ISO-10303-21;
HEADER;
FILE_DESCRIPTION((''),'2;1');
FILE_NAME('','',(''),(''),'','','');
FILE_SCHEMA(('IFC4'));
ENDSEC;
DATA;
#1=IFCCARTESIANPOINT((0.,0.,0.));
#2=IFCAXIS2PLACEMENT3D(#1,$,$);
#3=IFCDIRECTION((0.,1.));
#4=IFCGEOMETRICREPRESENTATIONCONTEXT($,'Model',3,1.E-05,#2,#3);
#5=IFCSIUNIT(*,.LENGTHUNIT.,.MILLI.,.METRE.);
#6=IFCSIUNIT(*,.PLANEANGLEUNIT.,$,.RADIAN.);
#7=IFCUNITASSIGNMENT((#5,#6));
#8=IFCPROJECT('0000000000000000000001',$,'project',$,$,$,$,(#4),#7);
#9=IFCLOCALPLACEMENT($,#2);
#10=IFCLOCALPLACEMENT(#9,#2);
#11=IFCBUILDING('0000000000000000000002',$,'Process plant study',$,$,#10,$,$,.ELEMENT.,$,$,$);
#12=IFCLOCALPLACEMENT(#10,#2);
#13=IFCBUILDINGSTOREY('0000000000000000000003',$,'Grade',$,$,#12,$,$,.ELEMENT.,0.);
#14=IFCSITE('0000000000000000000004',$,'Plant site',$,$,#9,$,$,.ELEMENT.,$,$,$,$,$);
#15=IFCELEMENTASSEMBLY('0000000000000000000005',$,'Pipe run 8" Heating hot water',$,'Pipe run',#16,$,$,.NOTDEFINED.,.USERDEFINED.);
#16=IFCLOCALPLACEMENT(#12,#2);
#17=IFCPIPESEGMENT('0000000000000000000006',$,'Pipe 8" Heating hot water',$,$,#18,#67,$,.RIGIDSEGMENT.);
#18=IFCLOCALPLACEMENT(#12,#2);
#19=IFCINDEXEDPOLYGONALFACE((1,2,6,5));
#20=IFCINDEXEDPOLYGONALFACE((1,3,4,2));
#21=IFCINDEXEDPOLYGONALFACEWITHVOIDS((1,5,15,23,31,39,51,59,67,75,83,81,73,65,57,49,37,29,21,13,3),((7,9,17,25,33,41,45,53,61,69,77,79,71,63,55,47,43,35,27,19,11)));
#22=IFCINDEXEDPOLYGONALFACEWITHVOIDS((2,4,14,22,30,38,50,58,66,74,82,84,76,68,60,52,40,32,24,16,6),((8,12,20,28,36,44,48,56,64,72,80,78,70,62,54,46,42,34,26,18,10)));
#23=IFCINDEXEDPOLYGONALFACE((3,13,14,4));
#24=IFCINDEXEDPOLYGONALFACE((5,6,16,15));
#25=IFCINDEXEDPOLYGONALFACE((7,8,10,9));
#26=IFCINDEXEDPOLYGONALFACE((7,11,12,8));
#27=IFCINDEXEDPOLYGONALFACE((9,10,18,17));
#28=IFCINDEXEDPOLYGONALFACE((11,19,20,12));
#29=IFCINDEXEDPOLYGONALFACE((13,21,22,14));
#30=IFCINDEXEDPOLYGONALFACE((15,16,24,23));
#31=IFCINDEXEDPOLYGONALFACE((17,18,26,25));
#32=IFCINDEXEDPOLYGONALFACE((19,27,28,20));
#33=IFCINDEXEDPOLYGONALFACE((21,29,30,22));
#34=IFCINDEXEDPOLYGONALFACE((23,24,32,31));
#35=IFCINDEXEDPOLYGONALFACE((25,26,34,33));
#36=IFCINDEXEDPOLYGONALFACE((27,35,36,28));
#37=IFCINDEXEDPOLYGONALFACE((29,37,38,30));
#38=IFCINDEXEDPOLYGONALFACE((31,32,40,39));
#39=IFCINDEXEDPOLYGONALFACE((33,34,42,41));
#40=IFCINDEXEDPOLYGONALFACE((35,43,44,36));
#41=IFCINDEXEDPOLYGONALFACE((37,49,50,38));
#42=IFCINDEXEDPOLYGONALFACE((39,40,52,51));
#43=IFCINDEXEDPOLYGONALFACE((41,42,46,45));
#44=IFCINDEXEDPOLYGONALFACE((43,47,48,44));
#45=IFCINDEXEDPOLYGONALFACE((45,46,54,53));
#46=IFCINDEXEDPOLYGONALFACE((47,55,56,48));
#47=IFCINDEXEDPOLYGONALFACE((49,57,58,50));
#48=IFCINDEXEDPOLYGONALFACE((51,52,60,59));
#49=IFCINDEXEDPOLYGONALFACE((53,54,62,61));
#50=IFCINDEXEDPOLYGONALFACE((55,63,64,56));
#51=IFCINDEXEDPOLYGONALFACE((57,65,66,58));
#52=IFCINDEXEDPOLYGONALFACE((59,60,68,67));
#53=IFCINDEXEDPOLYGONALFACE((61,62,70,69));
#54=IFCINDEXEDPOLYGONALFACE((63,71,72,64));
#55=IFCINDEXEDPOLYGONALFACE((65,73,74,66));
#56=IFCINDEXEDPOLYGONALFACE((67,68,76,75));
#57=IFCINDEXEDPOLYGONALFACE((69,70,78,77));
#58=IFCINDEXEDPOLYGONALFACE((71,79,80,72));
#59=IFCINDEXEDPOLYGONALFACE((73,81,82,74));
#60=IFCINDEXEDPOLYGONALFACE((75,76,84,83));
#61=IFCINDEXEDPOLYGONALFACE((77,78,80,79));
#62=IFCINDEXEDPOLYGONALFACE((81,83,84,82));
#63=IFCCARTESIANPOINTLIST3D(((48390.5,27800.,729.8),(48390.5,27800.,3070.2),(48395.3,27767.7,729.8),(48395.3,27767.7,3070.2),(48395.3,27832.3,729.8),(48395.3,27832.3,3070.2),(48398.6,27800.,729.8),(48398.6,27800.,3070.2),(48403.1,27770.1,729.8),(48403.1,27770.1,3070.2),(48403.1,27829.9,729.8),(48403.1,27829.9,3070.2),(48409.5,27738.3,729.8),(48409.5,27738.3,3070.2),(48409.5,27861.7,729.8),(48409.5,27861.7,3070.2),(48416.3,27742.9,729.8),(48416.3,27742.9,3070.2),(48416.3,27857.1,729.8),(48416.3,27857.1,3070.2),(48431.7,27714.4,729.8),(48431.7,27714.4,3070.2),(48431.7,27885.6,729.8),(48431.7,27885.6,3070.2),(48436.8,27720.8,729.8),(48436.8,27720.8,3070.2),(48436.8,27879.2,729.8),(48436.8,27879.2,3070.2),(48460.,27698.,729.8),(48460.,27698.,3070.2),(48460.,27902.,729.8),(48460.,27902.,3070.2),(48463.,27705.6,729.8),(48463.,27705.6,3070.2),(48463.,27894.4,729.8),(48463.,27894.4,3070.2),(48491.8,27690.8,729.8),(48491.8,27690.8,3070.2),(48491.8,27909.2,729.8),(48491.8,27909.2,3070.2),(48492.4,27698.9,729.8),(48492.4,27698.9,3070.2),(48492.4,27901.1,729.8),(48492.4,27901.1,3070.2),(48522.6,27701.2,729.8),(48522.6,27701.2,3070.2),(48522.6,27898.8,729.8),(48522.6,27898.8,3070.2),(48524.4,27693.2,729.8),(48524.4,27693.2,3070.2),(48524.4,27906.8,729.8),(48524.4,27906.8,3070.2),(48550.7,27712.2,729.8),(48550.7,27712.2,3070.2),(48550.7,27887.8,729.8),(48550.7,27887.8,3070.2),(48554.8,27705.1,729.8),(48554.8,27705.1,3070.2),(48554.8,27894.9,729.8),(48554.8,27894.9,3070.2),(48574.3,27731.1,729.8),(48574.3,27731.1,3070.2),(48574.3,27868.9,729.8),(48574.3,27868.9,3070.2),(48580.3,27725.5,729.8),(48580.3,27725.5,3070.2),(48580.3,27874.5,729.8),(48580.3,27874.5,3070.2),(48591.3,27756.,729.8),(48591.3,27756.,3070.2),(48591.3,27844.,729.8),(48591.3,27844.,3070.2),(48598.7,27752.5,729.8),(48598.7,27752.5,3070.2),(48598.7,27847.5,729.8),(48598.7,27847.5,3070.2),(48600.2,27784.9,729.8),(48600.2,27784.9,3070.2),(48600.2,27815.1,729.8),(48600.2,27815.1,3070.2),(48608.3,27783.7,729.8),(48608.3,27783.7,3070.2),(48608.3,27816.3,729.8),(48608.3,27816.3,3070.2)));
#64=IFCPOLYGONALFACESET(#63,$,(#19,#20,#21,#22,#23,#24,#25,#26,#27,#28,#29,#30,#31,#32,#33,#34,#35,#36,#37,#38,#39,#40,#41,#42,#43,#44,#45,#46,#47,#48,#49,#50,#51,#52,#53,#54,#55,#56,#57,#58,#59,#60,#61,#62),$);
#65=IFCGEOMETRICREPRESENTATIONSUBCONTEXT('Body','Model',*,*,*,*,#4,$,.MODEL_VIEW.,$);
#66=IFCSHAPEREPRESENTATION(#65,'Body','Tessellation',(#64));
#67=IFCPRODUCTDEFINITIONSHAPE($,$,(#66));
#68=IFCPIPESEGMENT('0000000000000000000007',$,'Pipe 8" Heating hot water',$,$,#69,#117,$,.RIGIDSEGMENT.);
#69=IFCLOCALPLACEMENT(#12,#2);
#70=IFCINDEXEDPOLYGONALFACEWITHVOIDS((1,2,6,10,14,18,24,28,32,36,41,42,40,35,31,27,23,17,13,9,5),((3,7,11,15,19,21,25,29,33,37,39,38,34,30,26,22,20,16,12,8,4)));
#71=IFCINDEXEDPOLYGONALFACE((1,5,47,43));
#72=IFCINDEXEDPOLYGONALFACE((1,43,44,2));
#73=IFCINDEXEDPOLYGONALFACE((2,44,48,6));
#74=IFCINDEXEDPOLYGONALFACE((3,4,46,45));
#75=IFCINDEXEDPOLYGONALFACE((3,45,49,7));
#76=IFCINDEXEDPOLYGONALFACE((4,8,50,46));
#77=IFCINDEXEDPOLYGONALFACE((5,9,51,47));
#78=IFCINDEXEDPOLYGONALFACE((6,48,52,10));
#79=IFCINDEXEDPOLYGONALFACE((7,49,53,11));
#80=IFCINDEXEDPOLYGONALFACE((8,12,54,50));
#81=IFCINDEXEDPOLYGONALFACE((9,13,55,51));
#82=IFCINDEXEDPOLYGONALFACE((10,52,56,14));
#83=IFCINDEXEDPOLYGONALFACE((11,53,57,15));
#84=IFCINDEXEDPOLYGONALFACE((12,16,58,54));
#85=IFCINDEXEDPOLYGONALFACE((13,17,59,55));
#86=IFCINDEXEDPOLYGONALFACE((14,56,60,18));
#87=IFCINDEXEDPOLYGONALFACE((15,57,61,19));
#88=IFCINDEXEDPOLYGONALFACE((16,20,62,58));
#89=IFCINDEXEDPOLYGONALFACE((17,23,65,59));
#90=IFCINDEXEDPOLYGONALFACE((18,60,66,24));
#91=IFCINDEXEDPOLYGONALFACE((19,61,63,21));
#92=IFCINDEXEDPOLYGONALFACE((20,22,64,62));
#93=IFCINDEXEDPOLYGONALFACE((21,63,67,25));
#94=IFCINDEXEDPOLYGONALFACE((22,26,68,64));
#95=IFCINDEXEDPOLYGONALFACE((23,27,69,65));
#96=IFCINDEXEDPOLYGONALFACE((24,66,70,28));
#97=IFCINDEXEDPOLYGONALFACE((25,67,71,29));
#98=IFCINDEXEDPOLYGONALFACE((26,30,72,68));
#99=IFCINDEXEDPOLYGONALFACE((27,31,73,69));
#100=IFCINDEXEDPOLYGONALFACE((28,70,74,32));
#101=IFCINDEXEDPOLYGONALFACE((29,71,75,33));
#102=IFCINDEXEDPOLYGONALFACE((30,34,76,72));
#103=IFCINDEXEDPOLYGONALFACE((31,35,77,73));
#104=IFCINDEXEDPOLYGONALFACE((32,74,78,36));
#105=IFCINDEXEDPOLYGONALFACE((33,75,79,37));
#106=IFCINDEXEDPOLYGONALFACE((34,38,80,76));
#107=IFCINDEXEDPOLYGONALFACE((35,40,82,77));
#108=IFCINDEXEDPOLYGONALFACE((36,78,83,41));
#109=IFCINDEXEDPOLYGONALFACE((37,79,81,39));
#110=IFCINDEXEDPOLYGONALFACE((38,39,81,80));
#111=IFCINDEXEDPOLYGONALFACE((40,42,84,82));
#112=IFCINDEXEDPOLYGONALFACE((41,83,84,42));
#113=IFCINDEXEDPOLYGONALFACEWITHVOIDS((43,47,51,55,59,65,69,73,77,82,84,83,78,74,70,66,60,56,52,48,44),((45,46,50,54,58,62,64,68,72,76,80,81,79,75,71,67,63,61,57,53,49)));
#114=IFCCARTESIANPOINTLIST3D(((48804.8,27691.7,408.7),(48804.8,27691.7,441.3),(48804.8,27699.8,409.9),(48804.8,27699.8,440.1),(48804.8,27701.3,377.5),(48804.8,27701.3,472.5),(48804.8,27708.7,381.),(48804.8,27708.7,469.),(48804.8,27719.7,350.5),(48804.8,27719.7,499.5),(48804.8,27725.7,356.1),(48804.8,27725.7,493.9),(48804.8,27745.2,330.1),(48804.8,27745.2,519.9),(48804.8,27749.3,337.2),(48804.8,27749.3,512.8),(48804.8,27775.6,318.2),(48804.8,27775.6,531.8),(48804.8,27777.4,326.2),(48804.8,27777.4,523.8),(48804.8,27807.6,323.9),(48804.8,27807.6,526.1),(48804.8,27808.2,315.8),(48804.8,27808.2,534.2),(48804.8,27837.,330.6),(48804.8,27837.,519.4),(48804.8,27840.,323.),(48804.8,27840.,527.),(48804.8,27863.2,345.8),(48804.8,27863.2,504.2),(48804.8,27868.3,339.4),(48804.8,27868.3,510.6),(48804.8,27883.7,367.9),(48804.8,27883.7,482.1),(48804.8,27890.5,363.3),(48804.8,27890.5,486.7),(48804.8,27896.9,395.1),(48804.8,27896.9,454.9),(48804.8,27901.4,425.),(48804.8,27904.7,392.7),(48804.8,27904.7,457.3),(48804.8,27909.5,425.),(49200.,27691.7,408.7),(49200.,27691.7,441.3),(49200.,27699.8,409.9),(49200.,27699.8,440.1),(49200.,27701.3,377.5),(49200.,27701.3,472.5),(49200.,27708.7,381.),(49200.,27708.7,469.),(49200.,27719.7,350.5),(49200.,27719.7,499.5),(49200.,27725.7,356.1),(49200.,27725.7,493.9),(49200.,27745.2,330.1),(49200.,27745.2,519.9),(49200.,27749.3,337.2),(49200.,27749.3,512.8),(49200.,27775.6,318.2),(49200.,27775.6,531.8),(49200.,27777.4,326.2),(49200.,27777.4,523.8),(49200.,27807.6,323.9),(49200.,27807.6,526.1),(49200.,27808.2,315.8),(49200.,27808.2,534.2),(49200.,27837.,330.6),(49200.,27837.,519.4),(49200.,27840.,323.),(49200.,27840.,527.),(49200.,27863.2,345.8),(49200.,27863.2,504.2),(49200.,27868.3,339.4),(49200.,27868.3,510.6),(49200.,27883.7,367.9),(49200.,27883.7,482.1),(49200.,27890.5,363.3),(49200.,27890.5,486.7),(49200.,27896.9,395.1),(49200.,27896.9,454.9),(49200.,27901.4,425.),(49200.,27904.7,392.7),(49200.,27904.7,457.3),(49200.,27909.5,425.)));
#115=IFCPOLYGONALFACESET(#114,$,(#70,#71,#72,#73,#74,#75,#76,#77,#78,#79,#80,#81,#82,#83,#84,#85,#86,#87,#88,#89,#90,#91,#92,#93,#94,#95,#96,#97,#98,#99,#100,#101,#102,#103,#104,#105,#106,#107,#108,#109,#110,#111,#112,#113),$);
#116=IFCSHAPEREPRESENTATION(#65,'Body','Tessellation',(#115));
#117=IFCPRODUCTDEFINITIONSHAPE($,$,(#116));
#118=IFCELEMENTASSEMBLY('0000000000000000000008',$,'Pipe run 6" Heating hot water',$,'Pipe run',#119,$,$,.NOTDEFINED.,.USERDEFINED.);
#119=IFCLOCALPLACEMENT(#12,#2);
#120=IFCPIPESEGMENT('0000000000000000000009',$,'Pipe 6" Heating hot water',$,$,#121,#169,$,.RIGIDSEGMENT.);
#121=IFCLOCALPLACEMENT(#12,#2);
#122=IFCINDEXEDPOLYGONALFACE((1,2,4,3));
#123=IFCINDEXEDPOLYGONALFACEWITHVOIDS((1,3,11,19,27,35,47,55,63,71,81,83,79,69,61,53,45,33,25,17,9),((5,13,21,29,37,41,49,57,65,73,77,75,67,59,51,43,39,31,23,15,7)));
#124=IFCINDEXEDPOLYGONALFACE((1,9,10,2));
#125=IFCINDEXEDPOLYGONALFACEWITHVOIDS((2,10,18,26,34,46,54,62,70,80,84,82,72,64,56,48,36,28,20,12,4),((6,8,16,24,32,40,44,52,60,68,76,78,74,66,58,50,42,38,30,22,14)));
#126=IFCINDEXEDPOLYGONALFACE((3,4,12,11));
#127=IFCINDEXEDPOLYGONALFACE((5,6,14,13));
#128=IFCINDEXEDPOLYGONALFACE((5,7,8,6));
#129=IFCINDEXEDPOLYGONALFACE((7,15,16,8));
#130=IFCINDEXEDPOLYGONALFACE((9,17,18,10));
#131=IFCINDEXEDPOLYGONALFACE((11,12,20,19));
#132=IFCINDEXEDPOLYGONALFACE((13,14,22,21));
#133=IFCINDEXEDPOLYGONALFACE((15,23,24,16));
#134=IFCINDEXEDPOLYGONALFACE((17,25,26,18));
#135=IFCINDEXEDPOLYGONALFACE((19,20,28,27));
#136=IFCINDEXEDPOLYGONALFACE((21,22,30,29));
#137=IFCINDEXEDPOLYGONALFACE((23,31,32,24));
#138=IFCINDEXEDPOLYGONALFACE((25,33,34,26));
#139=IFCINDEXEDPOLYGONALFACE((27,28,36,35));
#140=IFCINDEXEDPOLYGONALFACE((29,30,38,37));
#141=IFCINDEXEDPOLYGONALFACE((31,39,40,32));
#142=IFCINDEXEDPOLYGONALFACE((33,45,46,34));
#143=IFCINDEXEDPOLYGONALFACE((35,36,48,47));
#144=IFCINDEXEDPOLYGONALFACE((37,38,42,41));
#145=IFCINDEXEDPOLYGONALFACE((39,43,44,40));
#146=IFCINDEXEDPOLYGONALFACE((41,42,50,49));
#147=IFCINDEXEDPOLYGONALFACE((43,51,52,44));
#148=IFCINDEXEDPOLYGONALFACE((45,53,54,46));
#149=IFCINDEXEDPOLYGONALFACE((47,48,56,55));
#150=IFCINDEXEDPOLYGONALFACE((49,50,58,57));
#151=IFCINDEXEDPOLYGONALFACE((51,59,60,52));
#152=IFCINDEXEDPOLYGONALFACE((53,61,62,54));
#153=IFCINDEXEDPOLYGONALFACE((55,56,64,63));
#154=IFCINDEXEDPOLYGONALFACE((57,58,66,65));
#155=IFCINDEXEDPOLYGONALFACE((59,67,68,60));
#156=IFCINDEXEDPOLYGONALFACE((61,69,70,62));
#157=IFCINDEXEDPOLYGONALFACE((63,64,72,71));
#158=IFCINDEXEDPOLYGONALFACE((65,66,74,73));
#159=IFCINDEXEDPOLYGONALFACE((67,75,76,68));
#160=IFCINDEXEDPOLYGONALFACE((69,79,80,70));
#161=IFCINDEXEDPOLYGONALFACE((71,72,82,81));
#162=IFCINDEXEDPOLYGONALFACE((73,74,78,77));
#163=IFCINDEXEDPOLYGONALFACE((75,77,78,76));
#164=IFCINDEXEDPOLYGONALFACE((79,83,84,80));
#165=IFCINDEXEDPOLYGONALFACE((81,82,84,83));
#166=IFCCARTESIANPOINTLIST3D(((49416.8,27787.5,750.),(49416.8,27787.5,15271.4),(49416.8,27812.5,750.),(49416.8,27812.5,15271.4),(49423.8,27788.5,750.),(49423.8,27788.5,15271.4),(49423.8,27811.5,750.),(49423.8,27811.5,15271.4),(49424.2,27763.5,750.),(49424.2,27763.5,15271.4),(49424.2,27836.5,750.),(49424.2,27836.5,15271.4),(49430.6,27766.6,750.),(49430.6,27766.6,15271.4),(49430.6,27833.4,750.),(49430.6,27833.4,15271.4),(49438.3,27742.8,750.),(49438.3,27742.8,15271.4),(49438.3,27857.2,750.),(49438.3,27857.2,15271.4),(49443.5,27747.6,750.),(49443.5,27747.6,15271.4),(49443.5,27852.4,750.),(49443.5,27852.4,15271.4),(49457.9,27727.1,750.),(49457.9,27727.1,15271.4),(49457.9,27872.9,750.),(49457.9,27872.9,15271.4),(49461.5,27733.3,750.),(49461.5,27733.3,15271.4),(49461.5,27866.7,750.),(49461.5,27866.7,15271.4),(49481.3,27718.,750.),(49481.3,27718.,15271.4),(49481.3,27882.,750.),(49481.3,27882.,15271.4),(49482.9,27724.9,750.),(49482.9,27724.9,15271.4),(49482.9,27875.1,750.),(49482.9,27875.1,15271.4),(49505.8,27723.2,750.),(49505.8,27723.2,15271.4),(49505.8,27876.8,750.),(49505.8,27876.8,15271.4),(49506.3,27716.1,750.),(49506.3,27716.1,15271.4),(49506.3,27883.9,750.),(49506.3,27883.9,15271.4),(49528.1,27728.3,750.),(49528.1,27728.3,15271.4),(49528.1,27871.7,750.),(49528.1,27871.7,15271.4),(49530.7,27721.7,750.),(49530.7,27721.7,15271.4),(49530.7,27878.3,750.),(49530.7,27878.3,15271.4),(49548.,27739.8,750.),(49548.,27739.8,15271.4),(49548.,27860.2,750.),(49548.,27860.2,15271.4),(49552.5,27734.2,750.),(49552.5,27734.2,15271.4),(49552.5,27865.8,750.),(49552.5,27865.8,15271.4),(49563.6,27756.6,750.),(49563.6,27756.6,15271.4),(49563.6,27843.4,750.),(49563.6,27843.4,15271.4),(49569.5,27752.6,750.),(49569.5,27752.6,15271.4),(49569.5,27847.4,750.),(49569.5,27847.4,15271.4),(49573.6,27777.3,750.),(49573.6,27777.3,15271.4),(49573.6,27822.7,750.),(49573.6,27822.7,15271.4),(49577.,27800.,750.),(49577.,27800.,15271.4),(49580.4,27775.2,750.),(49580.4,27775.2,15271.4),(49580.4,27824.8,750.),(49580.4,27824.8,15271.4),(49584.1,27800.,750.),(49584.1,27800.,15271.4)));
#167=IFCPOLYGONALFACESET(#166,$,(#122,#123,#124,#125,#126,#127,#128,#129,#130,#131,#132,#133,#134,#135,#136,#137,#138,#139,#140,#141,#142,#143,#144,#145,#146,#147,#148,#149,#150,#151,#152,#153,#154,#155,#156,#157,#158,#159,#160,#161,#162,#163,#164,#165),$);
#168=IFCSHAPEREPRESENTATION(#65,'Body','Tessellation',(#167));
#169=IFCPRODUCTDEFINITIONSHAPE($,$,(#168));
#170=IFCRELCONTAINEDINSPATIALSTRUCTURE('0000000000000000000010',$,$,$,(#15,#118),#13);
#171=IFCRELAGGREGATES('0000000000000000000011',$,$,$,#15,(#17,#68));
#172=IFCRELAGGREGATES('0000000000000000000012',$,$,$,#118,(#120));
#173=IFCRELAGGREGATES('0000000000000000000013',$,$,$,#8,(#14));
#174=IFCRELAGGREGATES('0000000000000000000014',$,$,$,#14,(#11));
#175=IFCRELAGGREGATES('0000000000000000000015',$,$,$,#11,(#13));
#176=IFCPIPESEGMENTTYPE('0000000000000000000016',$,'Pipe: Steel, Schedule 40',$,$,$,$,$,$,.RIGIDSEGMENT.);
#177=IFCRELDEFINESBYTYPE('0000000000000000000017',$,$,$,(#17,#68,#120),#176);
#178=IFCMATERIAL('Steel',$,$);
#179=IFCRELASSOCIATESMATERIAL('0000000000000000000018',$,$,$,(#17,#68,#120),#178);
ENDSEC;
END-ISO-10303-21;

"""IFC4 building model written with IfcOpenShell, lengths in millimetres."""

from ifc_helpers import new_model, si_unit, direction, frame, origin, origin_with_axes, origin_2d, place, context, subcontext, project, spatial, hollow_circle, extrude, material, type_object, element, aggregate, save


model = new_model("IFC4")

# Units and contexts
model_context = context("Model", 3, precision=1e-05, world=origin(), true_north=direction((0.0, 1.0)))
body_context = subcontext(model_context, "Body", "Model", "MODEL_VIEW")
ifc_project = project(units=[si_unit("LENGTHUNIT", "METRE", prefix="MILLI"), si_unit("PLANEANGLEUNIT", "RADIAN")], contexts=[model_context])

# Site, building, storey
site_placement = place(None, origin())
site = spatial("IfcSite", under=ifc_project, at=site_placement, Name="Plant site", CompositionType="ELEMENT")
building_placement = place(site_placement, origin())
building = spatial("IfcBuilding", under=site, at=building_placement, Name="Process plant study", CompositionType="ELEMENT")
storey_placement = place(building_placement, origin())
storey = spatial("IfcBuildingStorey", under=building, at=storey_placement, Name="Grade", CompositionType="ELEMENT", Elevation=0.0)

# Element assemblies, pipe segments
ifc_material = material(Name="Steel")
pipe_segment_type = type_object("IfcPipeSegmentType", Name="Pipe: Steel, Schedule 40", PredefinedType="RIGIDSEGMENT")
assembly_1_placement = place(storey_placement, origin_with_axes())
assembly_1 = element("IfcElementAssembly", 1, at=assembly_1_placement, inside=storey, Name="Pipe run 8\" Heating hot water", ObjectType="Pipe run", AssemblyPlace="NOTDEFINED", PredefinedType="USERDEFINED")
pipe_segment_1_placement = place(storey_placement, origin_with_axes())
pipe_segment_1 = element("IfcPipeSegment", 2, at=pipe_segment_1_placement, type_object=pipe_segment_type, material=ifc_material, Name="Pipe 8\" Heating hot water", PredefinedType="RIGIDSEGMENT", context=body_context, shape_type="SweptSolid", body=[
    extrude(hollow_circle(Radius=109.5, WallThickness=8.2, at=origin_2d()), frame((48500.0, 27800.0, 3070.2), z_axis=(0.0, 0.0, -1.0), x_axis=(-1.0, 0.0, 0.0)), (0.0, 0.0, 1.0), 2340.4),
])
pipe_segment_2_placement = place(storey_placement, origin_with_axes())
pipe_segment_2 = element("IfcPipeSegment", 3, at=pipe_segment_2_placement, type_object=pipe_segment_type, material=ifc_material, Name="Pipe 8\" Heating hot water", PredefinedType="RIGIDSEGMENT", context=body_context, shape_type="SweptSolid", body=[
    extrude(hollow_circle(Radius=109.5, WallThickness=8.2, at=origin_2d()), frame((48804.8, 27800.0, 425.0), z_axis=(1.0, 0.0, 0.0), x_axis=(0.0, 1.0, 0.0)), (0.0, 0.0, 1.0), 395.2),
])
assembly_2_placement = place(storey_placement, origin_with_axes())
assembly_2 = element("IfcElementAssembly", 4, at=assembly_2_placement, inside=storey, Name="Pipe run 6\" Heating hot water", ObjectType="Pipe run", AssemblyPlace="NOTDEFINED", PredefinedType="USERDEFINED")
pipe_segment_3_placement = place(storey_placement, origin_with_axes())
pipe_segment_3 = element("IfcPipeSegment", 5, at=pipe_segment_3_placement, type_object=pipe_segment_type, material=ifc_material, Name="Pipe 6\" Heating hot water", PredefinedType="RIGIDSEGMENT", context=body_context, shape_type="SweptSolid", body=[
    extrude(hollow_circle(Radius=84.1, WallThickness=7.1, at=origin_2d()), frame((49500.0, 27800.0, 750.0), z_axis=(0.0, 0.0, 1.0), x_axis=(1.0, 0.0, 0.0)), (0.0, 0.0, 1.0), 14521.4),
])

aggregate(assembly_1, [pipe_segment_1, pipe_segment_2])
aggregate(assembly_2, [pipe_segment_3])

save(model, "model.ifc")
